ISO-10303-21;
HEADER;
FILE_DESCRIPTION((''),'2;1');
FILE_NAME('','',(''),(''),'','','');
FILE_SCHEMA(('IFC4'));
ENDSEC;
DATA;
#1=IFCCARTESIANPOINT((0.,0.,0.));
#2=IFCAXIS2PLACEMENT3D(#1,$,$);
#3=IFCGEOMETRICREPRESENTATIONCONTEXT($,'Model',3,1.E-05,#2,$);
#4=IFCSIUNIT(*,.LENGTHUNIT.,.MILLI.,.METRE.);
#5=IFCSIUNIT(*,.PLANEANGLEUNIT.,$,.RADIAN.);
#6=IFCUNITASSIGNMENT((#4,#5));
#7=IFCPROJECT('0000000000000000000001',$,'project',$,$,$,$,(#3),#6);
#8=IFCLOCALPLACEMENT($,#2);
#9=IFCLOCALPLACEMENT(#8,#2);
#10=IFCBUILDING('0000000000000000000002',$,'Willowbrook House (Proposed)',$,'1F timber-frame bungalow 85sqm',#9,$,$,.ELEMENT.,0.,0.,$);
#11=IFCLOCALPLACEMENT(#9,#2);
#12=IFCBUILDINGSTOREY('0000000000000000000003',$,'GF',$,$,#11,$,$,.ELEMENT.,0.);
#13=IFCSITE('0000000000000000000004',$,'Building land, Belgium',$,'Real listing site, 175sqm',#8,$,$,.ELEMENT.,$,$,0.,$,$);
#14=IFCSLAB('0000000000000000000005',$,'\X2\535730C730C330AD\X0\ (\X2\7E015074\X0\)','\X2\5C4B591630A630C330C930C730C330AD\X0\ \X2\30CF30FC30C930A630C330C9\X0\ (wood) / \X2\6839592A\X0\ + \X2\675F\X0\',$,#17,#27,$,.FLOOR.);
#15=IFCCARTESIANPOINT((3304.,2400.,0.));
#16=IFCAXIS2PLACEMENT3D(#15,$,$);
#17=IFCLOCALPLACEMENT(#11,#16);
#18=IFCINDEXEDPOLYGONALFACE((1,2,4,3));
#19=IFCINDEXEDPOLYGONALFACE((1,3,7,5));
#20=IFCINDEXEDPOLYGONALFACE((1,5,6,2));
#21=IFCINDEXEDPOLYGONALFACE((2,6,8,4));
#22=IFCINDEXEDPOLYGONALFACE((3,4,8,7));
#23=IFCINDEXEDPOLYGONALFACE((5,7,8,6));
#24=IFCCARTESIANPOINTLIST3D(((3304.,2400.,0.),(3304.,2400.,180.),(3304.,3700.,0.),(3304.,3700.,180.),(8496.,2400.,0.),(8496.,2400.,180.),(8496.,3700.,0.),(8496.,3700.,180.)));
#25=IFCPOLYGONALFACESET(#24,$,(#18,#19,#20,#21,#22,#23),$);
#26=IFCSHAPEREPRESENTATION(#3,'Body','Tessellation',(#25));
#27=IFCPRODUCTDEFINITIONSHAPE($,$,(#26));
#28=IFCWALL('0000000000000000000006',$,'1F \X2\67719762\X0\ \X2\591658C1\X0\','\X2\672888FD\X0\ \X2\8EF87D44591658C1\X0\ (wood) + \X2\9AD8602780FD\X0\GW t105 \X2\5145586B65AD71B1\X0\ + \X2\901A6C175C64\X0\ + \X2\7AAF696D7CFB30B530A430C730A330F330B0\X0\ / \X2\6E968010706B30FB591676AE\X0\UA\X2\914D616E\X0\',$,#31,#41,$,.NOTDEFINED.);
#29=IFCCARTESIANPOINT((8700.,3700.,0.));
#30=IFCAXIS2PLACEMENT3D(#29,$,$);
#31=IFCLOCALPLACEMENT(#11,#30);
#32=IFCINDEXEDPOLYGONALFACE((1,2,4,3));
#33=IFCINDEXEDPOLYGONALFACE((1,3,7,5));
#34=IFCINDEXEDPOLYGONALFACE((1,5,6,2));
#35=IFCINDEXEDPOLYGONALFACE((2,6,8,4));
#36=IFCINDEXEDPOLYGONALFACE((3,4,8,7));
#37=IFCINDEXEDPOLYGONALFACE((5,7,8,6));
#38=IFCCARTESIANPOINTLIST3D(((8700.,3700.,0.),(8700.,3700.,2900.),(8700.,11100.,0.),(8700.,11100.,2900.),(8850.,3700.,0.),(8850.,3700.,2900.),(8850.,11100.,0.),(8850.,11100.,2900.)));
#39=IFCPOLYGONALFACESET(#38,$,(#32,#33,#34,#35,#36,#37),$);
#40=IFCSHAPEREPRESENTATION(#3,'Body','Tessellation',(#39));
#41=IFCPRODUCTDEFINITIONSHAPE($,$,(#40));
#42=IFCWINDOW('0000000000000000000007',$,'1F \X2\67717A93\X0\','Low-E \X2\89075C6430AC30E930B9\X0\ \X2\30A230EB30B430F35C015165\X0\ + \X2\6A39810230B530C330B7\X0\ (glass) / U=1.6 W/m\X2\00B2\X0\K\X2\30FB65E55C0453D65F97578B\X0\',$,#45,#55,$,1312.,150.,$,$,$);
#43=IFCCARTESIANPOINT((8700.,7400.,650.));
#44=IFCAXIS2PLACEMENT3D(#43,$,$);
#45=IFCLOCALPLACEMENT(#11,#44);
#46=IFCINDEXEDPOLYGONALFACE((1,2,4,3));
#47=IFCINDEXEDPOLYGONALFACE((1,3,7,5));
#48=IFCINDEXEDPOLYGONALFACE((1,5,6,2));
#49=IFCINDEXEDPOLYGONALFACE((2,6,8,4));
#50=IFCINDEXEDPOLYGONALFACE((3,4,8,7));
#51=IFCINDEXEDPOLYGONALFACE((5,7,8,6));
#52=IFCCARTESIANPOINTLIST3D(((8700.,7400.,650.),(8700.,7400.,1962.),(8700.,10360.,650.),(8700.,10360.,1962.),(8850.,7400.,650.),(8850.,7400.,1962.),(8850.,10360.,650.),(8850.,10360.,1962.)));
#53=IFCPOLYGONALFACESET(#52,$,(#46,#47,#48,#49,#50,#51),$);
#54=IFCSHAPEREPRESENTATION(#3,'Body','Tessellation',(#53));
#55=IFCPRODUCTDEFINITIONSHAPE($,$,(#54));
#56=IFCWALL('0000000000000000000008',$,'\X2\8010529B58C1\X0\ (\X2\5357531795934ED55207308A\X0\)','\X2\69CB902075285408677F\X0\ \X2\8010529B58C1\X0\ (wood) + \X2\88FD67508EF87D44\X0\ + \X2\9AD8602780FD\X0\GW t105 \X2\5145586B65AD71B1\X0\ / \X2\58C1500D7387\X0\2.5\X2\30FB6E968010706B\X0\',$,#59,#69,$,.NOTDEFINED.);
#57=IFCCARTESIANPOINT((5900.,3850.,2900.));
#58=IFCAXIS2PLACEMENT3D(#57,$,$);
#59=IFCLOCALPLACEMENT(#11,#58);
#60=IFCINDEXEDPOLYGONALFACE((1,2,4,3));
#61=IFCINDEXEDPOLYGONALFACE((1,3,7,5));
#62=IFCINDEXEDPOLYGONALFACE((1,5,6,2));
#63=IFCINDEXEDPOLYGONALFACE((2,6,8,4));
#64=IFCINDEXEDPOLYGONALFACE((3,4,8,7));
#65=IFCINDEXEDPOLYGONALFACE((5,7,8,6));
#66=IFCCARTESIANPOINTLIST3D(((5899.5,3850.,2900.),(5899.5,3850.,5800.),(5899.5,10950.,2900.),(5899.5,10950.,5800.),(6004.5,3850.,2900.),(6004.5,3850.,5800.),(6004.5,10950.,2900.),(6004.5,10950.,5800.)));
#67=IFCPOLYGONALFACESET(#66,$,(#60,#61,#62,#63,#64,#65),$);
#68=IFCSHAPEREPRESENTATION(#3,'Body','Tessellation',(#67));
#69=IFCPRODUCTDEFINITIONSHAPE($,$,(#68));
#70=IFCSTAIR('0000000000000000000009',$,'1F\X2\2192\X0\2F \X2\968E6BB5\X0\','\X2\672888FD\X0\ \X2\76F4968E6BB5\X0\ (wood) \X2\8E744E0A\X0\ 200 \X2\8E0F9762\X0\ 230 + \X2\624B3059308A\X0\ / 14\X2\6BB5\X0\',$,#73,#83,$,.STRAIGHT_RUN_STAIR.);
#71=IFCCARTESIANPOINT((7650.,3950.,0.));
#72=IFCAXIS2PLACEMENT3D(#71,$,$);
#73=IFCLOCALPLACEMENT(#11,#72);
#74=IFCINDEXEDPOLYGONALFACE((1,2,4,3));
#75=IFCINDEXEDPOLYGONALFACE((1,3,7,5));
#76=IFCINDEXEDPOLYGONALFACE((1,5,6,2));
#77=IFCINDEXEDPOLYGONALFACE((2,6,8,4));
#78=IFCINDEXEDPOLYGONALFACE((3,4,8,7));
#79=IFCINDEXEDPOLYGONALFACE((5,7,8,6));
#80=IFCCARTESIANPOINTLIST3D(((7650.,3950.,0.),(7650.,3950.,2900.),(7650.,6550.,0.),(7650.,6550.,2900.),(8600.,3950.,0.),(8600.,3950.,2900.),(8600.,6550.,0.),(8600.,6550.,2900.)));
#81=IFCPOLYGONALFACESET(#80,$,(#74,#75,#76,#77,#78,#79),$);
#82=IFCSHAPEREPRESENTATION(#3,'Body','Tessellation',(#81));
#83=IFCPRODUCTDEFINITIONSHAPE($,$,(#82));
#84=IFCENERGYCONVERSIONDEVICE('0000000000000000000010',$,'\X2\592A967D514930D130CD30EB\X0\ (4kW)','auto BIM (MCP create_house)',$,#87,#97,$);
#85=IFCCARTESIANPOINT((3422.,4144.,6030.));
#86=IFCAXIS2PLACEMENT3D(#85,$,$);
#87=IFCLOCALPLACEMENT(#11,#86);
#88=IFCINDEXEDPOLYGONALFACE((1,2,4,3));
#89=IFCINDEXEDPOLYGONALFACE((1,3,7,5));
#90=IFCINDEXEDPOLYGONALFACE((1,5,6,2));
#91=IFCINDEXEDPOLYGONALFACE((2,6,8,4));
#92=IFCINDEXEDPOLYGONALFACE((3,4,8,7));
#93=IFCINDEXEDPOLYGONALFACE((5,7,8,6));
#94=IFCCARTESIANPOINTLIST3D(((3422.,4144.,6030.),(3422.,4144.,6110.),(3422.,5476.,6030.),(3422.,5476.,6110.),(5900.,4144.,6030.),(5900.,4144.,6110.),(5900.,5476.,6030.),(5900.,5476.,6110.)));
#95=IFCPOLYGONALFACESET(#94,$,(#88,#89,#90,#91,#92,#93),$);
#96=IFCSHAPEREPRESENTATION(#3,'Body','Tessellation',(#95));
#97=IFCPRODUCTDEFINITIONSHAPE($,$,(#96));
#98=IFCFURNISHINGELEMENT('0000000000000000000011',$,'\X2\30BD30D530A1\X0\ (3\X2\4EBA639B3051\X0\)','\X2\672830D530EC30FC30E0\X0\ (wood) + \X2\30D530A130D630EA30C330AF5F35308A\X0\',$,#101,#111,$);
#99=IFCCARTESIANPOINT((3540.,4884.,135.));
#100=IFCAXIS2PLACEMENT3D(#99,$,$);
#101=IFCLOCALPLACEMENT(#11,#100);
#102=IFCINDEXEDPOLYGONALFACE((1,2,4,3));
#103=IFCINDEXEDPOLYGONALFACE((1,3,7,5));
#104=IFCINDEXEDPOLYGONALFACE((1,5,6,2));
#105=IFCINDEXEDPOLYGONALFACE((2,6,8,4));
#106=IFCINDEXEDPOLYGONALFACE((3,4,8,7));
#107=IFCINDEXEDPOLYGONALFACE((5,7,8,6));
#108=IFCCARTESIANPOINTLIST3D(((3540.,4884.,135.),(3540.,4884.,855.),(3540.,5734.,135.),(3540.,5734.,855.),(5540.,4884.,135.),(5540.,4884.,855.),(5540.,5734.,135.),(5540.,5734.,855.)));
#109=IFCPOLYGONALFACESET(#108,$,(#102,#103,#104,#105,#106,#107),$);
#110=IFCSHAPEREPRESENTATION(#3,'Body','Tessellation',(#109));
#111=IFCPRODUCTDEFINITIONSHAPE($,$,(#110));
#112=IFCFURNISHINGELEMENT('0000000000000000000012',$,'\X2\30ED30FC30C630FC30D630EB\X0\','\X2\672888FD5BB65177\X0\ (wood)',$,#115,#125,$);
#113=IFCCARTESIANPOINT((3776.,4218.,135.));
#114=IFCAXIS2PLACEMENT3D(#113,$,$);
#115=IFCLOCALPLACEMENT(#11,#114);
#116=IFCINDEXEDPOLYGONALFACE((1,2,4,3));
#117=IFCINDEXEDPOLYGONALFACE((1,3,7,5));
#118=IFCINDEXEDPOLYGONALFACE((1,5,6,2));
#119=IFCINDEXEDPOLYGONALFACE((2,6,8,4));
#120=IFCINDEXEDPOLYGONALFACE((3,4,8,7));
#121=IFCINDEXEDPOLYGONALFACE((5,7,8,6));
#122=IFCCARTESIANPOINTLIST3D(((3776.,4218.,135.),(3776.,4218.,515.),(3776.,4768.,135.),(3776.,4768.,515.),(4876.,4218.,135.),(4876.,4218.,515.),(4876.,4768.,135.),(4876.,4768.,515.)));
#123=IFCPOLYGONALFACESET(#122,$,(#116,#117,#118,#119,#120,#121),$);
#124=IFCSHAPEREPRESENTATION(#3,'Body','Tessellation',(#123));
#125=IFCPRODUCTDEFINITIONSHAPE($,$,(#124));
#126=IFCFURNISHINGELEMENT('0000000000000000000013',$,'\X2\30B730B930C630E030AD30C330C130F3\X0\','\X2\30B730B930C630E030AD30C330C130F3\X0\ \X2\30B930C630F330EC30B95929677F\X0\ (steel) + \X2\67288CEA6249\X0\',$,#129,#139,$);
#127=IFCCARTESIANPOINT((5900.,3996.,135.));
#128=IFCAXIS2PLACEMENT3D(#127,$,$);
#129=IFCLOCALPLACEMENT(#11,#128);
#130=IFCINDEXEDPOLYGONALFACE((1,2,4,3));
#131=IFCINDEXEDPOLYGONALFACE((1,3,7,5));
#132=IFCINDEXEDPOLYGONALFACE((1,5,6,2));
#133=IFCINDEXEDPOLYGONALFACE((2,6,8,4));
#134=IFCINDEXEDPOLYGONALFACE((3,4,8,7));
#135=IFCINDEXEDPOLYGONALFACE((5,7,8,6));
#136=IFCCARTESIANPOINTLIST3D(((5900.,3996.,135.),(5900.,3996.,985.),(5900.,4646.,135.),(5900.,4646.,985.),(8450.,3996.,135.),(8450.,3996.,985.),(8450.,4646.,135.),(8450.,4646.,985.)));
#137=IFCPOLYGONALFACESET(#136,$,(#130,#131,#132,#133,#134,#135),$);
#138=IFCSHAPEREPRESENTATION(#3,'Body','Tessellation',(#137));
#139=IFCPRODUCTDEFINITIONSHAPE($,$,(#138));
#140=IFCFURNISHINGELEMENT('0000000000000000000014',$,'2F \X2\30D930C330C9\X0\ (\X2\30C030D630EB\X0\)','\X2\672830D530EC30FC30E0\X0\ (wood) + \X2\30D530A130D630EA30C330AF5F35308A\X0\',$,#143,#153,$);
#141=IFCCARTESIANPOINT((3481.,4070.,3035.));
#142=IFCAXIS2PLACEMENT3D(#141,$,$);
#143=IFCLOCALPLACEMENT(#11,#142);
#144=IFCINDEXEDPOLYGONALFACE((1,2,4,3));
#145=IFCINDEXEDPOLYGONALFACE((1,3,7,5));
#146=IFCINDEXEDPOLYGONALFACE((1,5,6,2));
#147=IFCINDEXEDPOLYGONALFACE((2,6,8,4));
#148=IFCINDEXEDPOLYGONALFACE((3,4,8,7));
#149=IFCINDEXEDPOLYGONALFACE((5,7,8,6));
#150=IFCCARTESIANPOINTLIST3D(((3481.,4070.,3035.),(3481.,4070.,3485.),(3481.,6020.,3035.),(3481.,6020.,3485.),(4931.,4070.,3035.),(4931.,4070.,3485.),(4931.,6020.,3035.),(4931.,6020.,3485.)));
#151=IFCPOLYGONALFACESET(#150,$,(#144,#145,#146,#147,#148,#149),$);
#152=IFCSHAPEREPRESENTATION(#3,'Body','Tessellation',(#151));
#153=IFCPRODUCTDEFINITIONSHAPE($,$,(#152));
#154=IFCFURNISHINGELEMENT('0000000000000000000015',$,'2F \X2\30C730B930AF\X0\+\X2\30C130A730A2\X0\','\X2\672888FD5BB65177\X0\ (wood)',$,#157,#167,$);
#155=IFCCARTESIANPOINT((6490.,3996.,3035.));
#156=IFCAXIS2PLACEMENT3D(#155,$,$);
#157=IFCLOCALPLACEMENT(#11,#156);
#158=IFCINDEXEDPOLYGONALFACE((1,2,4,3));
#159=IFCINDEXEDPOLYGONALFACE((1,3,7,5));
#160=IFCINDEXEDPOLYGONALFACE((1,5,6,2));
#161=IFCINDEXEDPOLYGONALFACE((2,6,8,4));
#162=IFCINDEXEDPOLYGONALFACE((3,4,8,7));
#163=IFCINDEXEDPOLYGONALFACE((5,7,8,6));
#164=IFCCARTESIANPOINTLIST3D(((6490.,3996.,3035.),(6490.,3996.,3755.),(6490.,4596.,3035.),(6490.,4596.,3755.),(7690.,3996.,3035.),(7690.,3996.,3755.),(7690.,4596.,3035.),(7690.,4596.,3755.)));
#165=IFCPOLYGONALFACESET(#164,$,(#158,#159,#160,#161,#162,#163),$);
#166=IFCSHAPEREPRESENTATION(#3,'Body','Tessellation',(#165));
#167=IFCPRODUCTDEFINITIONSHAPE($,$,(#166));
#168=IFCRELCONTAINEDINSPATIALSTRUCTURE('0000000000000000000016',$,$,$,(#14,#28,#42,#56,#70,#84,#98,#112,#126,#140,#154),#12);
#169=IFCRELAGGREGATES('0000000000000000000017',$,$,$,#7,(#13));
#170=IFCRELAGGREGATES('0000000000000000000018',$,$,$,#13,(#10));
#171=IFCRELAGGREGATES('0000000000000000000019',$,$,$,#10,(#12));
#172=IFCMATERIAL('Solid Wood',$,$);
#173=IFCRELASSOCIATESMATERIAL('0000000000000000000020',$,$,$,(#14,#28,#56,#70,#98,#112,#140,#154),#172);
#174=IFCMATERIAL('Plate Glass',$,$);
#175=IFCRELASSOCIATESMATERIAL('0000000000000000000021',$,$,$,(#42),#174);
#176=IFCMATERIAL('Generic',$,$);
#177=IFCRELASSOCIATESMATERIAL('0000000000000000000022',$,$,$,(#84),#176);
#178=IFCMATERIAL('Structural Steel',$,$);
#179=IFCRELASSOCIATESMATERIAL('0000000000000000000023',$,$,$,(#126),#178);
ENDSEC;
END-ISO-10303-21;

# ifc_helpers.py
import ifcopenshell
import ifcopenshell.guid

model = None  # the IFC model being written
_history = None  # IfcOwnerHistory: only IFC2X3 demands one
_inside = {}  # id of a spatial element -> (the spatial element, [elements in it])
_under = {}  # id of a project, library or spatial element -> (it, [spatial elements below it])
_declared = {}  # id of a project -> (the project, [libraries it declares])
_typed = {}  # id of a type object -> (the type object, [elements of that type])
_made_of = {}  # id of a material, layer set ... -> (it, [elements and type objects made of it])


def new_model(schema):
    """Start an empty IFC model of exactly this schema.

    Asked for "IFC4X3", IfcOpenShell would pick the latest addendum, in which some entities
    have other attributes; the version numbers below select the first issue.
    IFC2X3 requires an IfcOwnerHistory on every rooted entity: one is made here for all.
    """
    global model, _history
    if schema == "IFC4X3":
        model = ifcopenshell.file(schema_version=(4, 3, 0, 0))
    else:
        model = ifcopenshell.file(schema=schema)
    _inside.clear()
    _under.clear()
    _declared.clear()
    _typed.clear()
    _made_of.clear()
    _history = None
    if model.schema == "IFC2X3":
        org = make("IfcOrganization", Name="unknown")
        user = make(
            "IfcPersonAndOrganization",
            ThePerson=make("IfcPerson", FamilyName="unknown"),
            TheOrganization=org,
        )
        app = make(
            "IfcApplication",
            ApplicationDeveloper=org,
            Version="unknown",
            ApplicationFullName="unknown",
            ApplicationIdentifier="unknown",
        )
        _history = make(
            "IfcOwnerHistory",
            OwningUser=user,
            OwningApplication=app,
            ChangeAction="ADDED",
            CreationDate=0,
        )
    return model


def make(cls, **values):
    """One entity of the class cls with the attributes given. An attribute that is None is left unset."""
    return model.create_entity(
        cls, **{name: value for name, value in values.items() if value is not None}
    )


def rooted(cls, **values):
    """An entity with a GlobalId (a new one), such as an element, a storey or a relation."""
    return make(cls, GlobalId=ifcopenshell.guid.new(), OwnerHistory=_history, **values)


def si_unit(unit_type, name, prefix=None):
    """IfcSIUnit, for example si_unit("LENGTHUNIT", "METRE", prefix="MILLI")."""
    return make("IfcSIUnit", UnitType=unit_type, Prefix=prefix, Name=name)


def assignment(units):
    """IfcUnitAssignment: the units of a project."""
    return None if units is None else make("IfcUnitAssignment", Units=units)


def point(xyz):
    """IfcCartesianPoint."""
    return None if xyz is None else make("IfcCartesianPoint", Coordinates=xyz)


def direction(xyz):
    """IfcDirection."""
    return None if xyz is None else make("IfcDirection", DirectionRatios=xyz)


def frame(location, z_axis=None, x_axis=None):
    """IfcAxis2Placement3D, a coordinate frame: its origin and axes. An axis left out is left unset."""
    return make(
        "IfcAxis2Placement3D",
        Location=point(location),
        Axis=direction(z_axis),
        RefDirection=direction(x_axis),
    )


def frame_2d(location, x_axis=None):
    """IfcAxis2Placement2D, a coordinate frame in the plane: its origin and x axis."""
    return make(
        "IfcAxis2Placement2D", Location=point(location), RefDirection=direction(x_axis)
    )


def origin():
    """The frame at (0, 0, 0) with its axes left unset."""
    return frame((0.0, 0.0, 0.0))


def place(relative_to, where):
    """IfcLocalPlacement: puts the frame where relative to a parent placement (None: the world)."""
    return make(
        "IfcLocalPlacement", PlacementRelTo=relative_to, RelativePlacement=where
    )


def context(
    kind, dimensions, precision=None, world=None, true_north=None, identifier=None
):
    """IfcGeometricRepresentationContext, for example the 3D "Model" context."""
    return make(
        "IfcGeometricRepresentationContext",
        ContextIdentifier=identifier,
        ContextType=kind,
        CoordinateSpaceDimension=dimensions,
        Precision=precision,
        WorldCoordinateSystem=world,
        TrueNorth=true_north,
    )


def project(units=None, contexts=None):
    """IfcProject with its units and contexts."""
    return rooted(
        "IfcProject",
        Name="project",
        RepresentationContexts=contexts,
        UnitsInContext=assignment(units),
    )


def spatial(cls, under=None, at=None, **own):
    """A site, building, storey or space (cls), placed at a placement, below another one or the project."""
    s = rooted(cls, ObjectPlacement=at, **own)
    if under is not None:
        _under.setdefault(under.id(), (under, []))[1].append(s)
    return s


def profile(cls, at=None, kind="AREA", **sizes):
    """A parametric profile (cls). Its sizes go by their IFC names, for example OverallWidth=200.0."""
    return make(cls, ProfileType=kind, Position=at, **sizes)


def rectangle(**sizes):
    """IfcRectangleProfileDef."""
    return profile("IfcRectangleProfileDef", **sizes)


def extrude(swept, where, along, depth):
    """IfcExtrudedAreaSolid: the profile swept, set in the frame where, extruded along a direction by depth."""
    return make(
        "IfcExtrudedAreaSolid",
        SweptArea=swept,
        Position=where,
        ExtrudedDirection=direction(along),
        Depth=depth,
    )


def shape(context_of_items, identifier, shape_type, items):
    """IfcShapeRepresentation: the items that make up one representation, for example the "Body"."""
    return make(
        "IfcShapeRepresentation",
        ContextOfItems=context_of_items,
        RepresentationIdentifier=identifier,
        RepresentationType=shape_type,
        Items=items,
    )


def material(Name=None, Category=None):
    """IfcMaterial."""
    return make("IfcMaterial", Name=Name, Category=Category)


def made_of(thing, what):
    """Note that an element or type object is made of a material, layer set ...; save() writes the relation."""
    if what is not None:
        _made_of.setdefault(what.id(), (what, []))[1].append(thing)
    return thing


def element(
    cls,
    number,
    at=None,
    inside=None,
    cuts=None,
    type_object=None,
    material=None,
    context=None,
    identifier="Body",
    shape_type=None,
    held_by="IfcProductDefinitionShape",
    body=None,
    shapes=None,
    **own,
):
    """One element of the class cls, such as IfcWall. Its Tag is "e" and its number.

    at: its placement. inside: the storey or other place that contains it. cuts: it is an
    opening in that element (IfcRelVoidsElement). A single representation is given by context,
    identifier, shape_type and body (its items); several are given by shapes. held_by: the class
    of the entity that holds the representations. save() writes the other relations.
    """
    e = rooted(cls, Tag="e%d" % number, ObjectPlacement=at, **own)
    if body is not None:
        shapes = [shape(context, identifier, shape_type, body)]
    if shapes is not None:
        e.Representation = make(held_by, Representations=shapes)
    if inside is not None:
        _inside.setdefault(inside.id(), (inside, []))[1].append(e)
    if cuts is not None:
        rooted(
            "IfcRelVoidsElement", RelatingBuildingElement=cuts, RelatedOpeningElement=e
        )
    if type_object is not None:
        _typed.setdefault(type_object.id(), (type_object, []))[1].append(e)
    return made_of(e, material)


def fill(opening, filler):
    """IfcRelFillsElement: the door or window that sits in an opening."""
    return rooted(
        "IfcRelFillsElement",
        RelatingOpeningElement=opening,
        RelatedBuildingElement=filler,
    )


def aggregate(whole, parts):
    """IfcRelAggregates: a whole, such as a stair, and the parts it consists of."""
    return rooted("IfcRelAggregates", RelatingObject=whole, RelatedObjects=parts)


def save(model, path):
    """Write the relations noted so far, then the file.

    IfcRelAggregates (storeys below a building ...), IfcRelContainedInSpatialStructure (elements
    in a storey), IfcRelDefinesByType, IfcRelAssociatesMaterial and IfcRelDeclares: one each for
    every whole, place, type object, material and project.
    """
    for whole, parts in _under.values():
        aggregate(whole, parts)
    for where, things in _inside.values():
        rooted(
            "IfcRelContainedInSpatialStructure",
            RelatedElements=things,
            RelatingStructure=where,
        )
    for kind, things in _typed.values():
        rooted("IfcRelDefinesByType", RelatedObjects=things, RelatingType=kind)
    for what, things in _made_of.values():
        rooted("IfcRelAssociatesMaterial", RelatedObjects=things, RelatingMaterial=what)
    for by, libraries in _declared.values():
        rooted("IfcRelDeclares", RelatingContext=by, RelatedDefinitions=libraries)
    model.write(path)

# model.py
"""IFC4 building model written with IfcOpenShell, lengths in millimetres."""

from ifc_helpers import new_model, si_unit, frame, frame_2d, origin, place, context, project, spatial, rectangle, extrude, material, element, fill, save


model = new_model("IFC4")

# Units and contexts
model_context = context("Model", 3, precision=1e-05, world=origin())
ifc_project = project(units=[si_unit("LENGTHUNIT", "METRE", prefix="MILLI"), si_unit("PLANEANGLEUNIT", "RADIAN")], contexts=[model_context])

# Site, building, storey
site_placement = place(None, origin())
site = spatial("IfcSite", under=ifc_project, at=site_placement, Name="Building land, Belgium", ObjectType="Real listing site, 175sqm", CompositionType="ELEMENT", RefElevation=0.0)
building_placement = place(site_placement, origin())
building = spatial("IfcBuilding", under=site, at=building_placement, Name="Willowbrook House (Proposed)", ObjectType="1F timber-frame bungalow 85sqm", CompositionType="ELEMENT", ElevationOfRefHeight=0.0, ElevationOfTerrain=0.0)
storey_placement = place(building_placement, origin())
storey = spatial("IfcBuildingStorey", under=building, at=storey_placement, Name="GF", CompositionType="ELEMENT", Elevation=0.0)

# Slab
ifc_material_1 = material(Name="Solid Wood")
slab_placement = place(storey_placement, frame((3304.0, 2400.0, 0.0)))
element("IfcSlab", 1, at=slab_placement, inside=storey, material=ifc_material_1, Name="南デッキ (縁側)", Description="屋外ウッドデッキ ハードウッド (wood) / 根太 + 束", PredefinedType="FLOOR", context=model_context, shape_type="SweptSolid", body=[
    extrude(rectangle(XDim=5192.0, YDim=1300.0, at=frame_2d((2596.0, 650.0))), frame((3304.0, 2400.0, 0.0)), (0.0, 0.0, 1.0), 180.0),
])

# Wall, opening, window
wall_1_placement = place(storey_placement, frame((8700.0, 3700.0, 0.0)))
wall_1 = element("IfcWall", 2, at=wall_1_placement, inside=storey, material=ifc_material_1, Name="1F 東面 外壁", Description="木製 軸組外壁 (wood) + 高性能GW t105 充填断熱 + 通気層 + 窯業系サイディング / 準耐火・外皮UA配慮", PredefinedType="NOTDEFINED", context=model_context, shape_type="SweptSolid", body=[
    extrude(rectangle(XDim=150.0, YDim=7400.0, at=frame_2d((75.0, 3700.0))), frame((8700.0, 3700.0, 0.0)), (0.0, 0.0, 1.0), 2900.0),
])
opening_1_placement = place(storey_placement, frame((8700.0, 7400.0, 650.0)))
opening_1 = element("IfcOpeningElement", 3, at=opening_1_placement, cuts=wall_1, PredefinedType="NOTDEFINED", context=model_context, shape_type="SweptSolid", body=[
    extrude(rectangle(XDim=150.0, YDim=2960.0, at=frame_2d((75.0, 1480.0))), frame((8700.0, 7400.0, 650.0)), (0.0, 0.0, 1.0), 1312.0),
])
ifc_material_2 = material(Name="Plate Glass")
window_1_placement = place(storey_placement, frame((8700.0, 7400.0, 650.0)))
window_1 = element("IfcWindow", 4, at=window_1_placement, inside=storey, material=ifc_material_2, Name="1F 東窓", Description="Low-E 複層ガラス アルゴン封入 + 樹脂サッシ (glass) / U=1.6 W/m²K・日射取得型", OverallHeight=1312.0, OverallWidth=150.0, context=model_context, shape_type="SweptSolid", body=[
    extrude(rectangle(XDim=150.0, YDim=2960.0, at=frame_2d((75.0, 1480.0))), frame((8700.0, 7400.0, 650.0)), (0.0, 0.0, 1.0), 1312.0),
])
fill(opening_1, window_1)

# Wall
wall_2_placement = place(storey_placement, frame((5900.0, 3850.0, 2900.0)))
element("IfcWall", 5, at=wall_2_placement, inside=storey, material=ifc_material_1, Name="耐力壁 (南北間仕切り)", Description="構造用合板 耐力壁 (wood) + 製材軸組 + 高性能GW t105 充填断熱 / 壁倍率2.5・準耐火", PredefinedType="NOTDEFINED", context=model_context, shape_type="SweptSolid", body=[
    extrude(rectangle(XDim=105.0, YDim=7100.0, at=frame_2d((52.0, 3550.0))), frame((5900.0, 3850.0, 2900.0)), (0.0, 0.0, 1.0), 2900.0),
])

# Stair
stair_placement = place(storey_placement, frame((7650.0, 3950.0, 0.0)))
element("IfcStair", 6, at=stair_placement, inside=storey, material=ifc_material_1, Name="1F→2F 階段", Description="木製 直階段 (wood) 蹴上 200 踏面 230 + 手すり / 14段", PredefinedType="STRAIGHT_RUN_STAIR", context=model_context, shape_type="SweptSolid", body=[
    extrude(rectangle(XDim=950.0, YDim=2600.0, at=frame_2d((475.0, 1300.0))), frame((7650.0, 3950.0, 0.0)), (0.0, 0.0, 1.0), 2900.0),
])

# Energy conversion device
ifc_material_3 = material(Name="Generic")
energy_conversion_device_placement = place(storey_placement, frame((3422.0, 4144.0, 6030.0)))
element("IfcEnergyConversionDevice", 7, at=energy_conversion_device_placement, inside=storey, material=ifc_material_3, Name="太陽光パネル (4kW)", Description="auto BIM (MCP create_house)", context=model_context, shape_type="SweptSolid", body=[
    extrude(rectangle(XDim=2478.0, YDim=1332.0, at=frame_2d((1239.0, 666.0))), frame((3422.0, 4144.0, 6030.0)), (0.0, 0.0, 1.0), 80.0),
])

# Furnishing elements
furnishing_1_placement = place(storey_placement, frame((3540.0, 4884.0, 135.0)))
element("IfcFurnishingElement", 8, at=furnishing_1_placement, inside=storey, material=ifc_material_1, Name="ソファ (3人掛け)", Description="木フレーム (wood) + ファブリック張り", context=model_context, shape_type="SweptSolid", body=[
    extrude(rectangle(XDim=2000.0, YDim=850.0, at=frame_2d((1000.0, 425.0))), frame((3540.0, 4884.0, 135.0)), (0.0, 0.0, 1.0), 720.0),
])
furnishing_2_placement = place(storey_placement, frame((3776.0, 4218.0, 135.0)))
element("IfcFurnishingElement", 9, at=furnishing_2_placement, inside=storey, material=ifc_material_1, Name="ローテーブル", Description="木製家具 (wood)", context=model_context, shape_type="SweptSolid", body=[
    extrude(rectangle(XDim=1100.0, YDim=550.0, at=frame_2d((550.0, 275.0))), frame((3776.0, 4218.0, 135.0)), (0.0, 0.0, 1.0), 380.0),
])
ifc_material_4 = material(Name="Structural Steel")
furnishing_3_placement = place(storey_placement, frame((5900.0, 3996.0, 135.0)))
element("IfcFurnishingElement", 10, at=furnishing_3_placement, inside=storey, material=ifc_material_4, Name="システムキッチン", Description="システムキッチン ステンレス天板 (steel) + 木質扉", context=model_context, shape_type="SweptSolid", body=[
    extrude(rectangle(XDim=2550.0, YDim=650.0, at=frame_2d((1275.0, 325.0))), frame((5900.0, 3996.0, 135.0)), (0.0, 0.0, 1.0), 850.0),
])
furnishing_4_placement = place(storey_placement, frame((3481.0, 4070.0, 3035.0)))
element("IfcFurnishingElement", 11, at=furnishing_4_placement, inside=storey, material=ifc_material_1, Name="2F ベッド (ダブル)", Description="木フレーム (wood) + ファブリック張り", context=model_context, shape_type="SweptSolid", body=[
    extrude(rectangle(XDim=1450.0, YDim=1950.0, at=frame_2d((725.0, 975.0))), frame((3481.0, 4070.0, 3035.0)), (0.0, 0.0, 1.0), 450.0),
])
furnishing_5_placement = place(storey_placement, frame((6490.0, 3996.0, 3035.0)))
element("IfcFurnishingElement", 12, at=furnishing_5_placement, inside=storey, material=ifc_material_1, Name="2F デスク+チェア", Description="木製家具 (wood)", context=model_context, shape_type="SweptSolid", body=[
    extrude(rectangle(XDim=1200.0, YDim=600.0, at=frame_2d((600.0, 300.0))), frame((6490.0, 3996.0, 3035.0)), (0.0, 0.0, 1.0), 720.0),
])

save(model, "model.ifc")
